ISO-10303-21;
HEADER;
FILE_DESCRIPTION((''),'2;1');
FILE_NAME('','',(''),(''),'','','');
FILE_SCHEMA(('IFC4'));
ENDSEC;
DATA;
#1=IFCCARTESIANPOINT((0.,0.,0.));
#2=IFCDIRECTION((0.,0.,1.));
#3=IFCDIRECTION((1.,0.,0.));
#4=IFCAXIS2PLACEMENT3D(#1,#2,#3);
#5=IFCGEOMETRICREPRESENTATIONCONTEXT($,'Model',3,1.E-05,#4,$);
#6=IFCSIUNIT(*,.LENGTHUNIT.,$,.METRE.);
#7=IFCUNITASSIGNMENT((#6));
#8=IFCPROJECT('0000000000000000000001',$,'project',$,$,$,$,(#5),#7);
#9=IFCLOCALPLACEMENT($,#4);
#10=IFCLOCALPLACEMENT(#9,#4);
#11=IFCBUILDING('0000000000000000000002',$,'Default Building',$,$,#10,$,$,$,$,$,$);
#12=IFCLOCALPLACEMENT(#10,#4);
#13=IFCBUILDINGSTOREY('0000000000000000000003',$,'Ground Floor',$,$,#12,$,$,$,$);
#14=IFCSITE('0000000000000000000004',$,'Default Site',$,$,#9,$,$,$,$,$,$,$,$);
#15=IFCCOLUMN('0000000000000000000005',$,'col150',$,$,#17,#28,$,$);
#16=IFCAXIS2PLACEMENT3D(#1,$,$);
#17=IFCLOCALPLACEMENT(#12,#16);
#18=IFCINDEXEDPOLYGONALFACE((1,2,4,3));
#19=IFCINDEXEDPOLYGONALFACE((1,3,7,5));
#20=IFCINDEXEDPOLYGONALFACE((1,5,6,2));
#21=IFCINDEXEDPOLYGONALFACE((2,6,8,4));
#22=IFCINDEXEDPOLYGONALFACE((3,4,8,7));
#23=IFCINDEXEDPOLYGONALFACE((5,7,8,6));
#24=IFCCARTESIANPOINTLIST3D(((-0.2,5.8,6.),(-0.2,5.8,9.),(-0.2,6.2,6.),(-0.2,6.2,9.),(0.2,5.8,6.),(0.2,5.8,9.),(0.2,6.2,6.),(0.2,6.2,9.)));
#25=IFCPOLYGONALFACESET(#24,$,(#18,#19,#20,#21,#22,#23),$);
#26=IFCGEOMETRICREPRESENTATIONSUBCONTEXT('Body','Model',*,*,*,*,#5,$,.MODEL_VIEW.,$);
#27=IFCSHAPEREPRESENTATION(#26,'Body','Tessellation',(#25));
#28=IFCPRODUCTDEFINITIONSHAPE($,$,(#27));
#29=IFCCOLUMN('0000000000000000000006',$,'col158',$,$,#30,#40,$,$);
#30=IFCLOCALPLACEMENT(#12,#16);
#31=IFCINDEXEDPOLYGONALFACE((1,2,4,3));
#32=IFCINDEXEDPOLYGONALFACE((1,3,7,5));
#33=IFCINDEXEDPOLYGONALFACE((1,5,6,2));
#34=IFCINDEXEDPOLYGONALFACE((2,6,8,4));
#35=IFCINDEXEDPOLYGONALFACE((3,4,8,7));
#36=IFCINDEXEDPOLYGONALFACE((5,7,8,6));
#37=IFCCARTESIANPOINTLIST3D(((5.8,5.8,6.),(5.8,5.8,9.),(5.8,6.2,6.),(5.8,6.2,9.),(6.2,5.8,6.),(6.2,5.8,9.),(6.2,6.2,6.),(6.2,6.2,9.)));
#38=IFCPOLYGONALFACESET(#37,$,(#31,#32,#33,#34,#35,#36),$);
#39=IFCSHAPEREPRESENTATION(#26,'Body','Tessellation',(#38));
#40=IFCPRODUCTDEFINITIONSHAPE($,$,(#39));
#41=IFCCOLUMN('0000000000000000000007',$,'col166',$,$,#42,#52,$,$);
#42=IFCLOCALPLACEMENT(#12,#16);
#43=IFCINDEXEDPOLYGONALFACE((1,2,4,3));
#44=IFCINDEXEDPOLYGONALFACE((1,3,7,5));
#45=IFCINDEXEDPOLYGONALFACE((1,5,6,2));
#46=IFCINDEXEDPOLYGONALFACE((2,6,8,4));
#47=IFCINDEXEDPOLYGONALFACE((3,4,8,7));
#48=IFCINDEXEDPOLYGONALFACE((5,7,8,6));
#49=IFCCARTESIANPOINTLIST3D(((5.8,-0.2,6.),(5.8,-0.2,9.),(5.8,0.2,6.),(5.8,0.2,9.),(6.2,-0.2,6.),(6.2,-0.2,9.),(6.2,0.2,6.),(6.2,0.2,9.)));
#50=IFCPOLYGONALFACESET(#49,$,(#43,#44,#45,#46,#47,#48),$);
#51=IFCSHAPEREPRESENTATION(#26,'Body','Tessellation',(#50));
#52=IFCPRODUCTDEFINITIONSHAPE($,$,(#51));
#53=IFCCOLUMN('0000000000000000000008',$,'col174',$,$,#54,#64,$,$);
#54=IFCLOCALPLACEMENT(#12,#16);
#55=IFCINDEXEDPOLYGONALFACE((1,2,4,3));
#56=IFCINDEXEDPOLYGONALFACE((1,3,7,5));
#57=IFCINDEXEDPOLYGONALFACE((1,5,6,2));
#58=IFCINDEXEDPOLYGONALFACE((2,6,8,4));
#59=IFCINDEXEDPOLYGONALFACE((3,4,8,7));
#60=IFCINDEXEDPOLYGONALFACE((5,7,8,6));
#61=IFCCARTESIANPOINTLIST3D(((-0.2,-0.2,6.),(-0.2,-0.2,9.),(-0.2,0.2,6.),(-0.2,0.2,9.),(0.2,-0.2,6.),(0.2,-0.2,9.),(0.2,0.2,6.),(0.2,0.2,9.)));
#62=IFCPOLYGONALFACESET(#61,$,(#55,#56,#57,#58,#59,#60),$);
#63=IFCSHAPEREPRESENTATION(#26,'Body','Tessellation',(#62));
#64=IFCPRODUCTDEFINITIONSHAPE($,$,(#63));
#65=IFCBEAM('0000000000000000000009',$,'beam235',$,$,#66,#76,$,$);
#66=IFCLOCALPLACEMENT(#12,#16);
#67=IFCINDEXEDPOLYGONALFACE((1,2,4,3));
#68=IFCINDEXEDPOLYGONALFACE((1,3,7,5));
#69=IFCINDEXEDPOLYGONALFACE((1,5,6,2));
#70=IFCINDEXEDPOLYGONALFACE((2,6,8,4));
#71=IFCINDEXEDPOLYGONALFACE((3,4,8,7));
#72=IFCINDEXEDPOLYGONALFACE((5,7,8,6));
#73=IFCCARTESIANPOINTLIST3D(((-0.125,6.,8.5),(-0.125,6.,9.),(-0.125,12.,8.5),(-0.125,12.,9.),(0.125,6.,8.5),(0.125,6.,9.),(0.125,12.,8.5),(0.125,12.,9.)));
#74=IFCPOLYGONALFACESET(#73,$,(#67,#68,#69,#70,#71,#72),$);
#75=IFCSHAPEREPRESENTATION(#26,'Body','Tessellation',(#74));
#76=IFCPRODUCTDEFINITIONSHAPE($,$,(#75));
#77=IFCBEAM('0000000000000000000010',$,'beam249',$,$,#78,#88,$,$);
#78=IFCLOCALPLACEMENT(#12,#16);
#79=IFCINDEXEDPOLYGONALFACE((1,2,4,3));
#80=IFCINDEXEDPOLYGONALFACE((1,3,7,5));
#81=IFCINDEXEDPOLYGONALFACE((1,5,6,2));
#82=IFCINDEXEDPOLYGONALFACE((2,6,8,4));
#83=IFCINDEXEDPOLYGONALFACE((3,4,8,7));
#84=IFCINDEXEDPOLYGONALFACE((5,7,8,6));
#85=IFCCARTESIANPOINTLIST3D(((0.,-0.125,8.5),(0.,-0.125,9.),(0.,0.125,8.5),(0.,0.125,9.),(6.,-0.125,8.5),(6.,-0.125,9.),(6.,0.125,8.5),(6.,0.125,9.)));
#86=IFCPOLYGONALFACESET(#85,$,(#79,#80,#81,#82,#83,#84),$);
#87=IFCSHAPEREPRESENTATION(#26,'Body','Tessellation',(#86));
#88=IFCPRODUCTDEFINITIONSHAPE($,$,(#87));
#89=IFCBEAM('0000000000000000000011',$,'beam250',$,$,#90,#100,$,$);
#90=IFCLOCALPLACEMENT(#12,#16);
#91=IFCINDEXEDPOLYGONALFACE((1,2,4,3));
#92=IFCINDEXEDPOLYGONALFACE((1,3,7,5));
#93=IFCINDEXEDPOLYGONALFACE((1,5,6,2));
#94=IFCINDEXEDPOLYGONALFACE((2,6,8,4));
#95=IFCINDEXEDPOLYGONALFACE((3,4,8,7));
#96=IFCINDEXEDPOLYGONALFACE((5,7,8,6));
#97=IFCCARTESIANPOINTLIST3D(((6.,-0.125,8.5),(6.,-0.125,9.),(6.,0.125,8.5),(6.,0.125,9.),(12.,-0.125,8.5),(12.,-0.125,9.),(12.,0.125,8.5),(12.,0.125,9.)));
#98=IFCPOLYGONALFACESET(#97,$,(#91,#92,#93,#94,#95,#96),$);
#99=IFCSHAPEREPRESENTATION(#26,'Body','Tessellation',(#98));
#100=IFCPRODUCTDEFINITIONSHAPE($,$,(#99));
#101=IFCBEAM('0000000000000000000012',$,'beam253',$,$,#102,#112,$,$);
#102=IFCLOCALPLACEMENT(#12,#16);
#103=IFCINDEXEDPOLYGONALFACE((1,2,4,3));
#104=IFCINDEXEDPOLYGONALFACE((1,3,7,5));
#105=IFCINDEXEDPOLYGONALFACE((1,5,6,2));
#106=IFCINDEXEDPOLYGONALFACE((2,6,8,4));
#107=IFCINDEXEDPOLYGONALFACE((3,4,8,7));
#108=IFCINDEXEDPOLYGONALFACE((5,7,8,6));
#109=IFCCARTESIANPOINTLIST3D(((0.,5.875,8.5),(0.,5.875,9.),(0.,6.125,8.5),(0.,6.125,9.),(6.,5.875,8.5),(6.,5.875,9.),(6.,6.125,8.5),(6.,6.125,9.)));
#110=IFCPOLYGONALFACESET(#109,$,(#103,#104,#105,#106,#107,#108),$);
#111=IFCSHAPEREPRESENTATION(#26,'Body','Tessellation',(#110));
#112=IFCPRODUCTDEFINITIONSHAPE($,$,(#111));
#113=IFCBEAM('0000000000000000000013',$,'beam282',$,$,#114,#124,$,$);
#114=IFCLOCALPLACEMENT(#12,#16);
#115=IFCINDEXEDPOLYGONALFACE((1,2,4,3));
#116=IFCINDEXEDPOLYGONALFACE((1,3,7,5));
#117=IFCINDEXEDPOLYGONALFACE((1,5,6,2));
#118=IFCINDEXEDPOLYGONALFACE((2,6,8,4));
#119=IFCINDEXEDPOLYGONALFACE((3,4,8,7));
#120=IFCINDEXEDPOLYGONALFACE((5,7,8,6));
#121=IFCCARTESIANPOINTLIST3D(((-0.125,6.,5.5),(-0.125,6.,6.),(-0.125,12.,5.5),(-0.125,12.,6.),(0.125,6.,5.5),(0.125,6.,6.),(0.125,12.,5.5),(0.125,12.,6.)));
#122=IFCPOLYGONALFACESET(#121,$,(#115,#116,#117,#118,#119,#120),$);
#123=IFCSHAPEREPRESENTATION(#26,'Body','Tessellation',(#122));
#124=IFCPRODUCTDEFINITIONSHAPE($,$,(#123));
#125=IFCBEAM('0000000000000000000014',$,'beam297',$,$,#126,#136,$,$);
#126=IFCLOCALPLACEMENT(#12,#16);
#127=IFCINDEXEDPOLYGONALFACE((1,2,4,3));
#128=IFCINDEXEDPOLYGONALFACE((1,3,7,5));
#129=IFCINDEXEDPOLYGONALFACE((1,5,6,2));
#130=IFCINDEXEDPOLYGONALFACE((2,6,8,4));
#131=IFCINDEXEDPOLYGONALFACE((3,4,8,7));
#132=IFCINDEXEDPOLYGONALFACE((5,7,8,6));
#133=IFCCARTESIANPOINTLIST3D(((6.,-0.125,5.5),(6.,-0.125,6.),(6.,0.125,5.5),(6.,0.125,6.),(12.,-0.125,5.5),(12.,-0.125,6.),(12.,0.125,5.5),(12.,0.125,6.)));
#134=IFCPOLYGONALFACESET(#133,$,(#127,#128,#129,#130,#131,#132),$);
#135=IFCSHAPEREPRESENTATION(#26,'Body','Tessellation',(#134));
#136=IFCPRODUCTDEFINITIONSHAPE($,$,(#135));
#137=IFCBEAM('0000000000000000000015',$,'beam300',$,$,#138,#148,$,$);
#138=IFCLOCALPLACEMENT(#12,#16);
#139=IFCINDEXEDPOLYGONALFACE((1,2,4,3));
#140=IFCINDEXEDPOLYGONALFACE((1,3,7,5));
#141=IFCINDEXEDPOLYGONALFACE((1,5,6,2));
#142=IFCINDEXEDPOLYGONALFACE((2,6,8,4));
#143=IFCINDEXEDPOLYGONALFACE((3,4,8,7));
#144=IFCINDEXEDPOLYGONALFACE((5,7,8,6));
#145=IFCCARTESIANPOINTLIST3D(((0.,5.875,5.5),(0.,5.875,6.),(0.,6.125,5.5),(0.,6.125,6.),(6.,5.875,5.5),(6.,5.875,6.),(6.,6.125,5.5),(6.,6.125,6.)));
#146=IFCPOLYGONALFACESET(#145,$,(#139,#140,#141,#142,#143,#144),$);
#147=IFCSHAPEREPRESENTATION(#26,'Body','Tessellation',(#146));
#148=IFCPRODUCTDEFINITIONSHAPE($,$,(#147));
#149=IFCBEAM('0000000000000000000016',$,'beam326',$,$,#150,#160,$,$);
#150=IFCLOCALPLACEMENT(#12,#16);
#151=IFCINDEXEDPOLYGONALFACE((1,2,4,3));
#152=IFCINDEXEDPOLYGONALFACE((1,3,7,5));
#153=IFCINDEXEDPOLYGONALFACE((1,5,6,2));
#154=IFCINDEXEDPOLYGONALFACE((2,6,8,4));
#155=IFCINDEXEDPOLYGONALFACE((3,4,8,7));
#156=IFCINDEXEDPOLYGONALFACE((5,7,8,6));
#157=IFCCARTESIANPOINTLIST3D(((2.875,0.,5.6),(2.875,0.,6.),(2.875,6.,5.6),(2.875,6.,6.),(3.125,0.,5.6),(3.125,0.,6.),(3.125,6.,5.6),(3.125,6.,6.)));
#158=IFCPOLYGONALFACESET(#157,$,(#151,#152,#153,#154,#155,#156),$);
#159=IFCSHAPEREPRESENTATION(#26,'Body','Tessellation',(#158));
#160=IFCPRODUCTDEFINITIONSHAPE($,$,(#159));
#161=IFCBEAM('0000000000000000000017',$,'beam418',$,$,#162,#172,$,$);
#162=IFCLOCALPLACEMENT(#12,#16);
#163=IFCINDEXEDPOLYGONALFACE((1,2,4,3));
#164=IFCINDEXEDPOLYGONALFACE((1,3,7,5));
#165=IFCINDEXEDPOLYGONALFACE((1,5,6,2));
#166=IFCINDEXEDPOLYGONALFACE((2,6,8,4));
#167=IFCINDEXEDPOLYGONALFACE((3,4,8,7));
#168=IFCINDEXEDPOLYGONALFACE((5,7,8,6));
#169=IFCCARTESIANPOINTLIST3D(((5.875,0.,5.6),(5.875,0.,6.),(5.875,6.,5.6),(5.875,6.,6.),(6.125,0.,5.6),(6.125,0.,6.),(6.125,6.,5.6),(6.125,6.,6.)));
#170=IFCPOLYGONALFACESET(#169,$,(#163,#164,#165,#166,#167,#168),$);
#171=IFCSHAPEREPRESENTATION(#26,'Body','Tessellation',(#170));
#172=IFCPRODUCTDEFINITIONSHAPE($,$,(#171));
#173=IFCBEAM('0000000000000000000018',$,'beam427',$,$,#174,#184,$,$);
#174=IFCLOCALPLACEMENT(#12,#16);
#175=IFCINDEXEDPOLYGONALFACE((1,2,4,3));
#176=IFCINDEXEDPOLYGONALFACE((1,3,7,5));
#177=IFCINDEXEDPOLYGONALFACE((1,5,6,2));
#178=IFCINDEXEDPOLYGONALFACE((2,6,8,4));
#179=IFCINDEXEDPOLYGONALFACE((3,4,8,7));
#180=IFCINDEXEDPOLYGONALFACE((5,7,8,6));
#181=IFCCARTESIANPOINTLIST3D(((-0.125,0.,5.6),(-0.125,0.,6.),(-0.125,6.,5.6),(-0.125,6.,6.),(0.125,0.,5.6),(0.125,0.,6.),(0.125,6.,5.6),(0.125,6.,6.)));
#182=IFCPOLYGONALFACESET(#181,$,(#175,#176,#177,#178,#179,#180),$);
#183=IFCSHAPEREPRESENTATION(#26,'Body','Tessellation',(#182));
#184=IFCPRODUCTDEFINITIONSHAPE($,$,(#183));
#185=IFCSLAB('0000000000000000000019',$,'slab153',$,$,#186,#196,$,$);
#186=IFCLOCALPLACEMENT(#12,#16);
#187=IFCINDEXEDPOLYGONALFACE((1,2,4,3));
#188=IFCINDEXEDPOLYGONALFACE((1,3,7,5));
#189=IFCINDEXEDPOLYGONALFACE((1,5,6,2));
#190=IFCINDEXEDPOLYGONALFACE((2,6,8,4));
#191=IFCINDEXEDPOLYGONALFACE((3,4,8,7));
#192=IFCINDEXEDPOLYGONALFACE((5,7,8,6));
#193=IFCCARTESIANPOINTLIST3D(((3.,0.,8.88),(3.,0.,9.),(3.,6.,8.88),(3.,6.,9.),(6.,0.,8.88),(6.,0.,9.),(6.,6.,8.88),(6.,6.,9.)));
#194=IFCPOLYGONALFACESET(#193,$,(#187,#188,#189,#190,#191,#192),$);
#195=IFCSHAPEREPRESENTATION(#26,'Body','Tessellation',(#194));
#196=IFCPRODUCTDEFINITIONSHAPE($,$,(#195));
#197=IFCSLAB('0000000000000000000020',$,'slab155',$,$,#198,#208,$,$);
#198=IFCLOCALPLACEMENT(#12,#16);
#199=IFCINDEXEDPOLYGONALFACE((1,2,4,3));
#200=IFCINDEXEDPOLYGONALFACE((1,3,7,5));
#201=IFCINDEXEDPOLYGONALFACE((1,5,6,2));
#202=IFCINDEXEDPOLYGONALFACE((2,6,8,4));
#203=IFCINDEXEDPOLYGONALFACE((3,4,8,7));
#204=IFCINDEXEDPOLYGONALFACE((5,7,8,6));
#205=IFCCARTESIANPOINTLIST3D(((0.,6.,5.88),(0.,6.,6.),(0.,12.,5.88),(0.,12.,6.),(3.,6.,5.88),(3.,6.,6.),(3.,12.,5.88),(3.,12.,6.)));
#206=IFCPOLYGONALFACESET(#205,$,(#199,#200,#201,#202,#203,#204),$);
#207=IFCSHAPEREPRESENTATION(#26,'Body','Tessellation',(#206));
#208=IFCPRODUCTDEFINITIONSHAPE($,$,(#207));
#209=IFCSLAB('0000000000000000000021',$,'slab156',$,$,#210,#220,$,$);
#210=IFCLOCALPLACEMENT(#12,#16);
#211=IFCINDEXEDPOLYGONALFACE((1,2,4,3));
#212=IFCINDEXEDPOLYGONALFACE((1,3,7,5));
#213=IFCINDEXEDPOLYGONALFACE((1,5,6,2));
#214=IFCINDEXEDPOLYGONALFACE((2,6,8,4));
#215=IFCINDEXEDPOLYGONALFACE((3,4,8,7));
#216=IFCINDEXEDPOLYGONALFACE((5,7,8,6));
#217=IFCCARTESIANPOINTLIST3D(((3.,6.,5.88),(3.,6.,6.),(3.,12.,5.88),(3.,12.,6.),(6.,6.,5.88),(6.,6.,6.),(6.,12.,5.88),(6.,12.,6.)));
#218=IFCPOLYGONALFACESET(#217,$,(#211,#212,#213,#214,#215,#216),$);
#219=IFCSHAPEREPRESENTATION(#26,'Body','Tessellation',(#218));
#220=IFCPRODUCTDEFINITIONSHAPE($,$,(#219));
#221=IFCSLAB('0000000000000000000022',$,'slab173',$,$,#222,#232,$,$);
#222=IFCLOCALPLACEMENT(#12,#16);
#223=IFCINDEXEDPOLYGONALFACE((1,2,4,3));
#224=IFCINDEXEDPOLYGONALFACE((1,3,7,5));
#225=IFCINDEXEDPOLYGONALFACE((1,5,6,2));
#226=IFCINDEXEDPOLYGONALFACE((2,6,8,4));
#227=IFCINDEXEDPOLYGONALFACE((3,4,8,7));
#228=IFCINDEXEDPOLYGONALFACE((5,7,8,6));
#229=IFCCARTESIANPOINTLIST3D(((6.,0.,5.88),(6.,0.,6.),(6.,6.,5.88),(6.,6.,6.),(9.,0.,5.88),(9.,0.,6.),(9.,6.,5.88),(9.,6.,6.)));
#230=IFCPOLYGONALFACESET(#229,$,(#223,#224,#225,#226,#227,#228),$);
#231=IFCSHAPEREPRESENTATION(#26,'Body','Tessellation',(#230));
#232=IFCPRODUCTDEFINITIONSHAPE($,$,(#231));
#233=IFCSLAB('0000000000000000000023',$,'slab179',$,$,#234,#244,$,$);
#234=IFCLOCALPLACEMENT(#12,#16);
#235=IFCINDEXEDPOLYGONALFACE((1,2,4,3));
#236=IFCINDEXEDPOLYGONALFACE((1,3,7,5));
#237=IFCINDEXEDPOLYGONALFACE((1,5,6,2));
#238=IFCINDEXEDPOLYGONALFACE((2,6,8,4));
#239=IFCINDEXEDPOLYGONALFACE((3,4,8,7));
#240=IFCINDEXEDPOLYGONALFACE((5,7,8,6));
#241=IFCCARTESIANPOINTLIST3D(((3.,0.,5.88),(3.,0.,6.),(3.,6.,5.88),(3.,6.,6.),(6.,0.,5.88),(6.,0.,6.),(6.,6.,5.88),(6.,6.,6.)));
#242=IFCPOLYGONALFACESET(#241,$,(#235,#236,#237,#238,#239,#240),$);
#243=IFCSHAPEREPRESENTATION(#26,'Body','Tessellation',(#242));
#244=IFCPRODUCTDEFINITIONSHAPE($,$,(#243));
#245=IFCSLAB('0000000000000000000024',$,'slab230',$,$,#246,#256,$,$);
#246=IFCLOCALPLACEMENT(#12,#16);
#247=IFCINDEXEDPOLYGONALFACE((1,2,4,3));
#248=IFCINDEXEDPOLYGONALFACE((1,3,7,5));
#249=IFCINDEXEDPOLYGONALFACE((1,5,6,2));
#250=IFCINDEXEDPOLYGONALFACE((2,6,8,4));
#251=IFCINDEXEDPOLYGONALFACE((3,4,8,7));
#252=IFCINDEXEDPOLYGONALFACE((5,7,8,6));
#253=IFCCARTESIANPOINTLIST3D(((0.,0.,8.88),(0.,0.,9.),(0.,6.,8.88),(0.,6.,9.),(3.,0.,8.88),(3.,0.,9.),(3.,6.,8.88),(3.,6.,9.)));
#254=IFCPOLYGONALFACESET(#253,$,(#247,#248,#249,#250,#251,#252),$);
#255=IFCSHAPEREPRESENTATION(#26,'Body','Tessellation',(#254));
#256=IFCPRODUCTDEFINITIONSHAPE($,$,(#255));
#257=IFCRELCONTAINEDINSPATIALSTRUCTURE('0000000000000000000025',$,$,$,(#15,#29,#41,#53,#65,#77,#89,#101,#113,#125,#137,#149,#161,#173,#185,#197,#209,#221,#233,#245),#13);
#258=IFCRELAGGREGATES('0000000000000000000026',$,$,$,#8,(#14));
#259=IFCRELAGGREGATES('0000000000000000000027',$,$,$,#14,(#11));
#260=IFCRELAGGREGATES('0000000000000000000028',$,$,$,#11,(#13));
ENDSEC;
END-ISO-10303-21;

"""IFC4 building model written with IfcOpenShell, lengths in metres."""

from ifc_helpers import new_model, si_unit, frame, origin_with_axes, place, context, subcontext, project, spatial, indexed_curve, outline, extrude, element, save


model = new_model("IFC4")

# Units and contexts
model_context = context("Model", 3, precision=1e-05, world=origin_with_axes())
body_context = subcontext(model_context, "Body", "Model", "MODEL_VIEW")
ifc_project = project(units=[si_unit("LENGTHUNIT", "METRE")], contexts=[model_context])

# Site, building, storey
site_placement = place(None, origin_with_axes())
site = spatial("IfcSite", under=ifc_project, at=site_placement, Name="Default Site")
building_placement = place(site_placement, origin_with_axes())
building = spatial("IfcBuilding", under=site, at=building_placement, Name="Default Building")
storey_placement = place(building_placement, origin_with_axes())
storey = spatial("IfcBuildingStorey", under=building, at=storey_placement, Name="Ground Floor")

# Columns
for number, where, z_axis, x_axis, name in (
    (1, (-0.2, 5.8, 6.0), (0.0, 0.0, 1.0), (1.0, 0.0, 0.0), "col150"),
    (2, (5.8, 5.8, 6.0), (0.0, 0.0, 1.0), (1.0, 0.0, 0.0), "col158"),
    (3, (5.8, -0.2, 6.0), (0.0, 0.0, 1.0), (1.0, 0.0, 0.0), "col166"),
    (4, (-0.2, -0.2, 6.0), (0.0, 0.0, 1.0), (1.0, 0.0, 0.0), "col174"),
):
    element("IfcColumn", number, at=place(storey_placement, frame(where, z_axis=z_axis, x_axis=x_axis)), inside=storey, Name=name, context=body_context, shape_type="SweptSolid", body=[
        extrude(outline(indexed_curve([(0.0, 0.0), (0.0, 0.4), (0.4, 0.4), (0.4, 0.0), (0.0, 0.0)], self_intersect=False)), origin_with_axes(), (0.0, 0.0, 1.0), 3.0),
    ])

# Beams
for number, where, z_axis, x_axis, name in (
    (5, (0.125, 6.0, 8.5), (0.0, 0.0, 1.0), (0.0, 1.0, 0.0), "beam235"),
    (6, (0.0, -0.125, 8.5), (0.0, 0.0, 1.0), (1.0, 0.0, 0.0), "beam249"),
    (7, (6.0, -0.125, 8.5), (0.0, 0.0, 1.0), (1.0, 0.0, 0.0), "beam250"),
    (8, (0.0, 5.875, 8.5), (0.0, 0.0, 1.0), (1.0, 0.0, 0.0), "beam253"),
    (9, (0.125, 6.0, 5.5), (0.0, 0.0, 1.0), (0.0, 1.0, 0.0), "beam282"),
    (10, (6.0, -0.125, 5.5), (0.0, 0.0, 1.0), (1.0, 0.0, 0.0), "beam297"),
    (11, (0.0, 5.875, 5.5), (0.0, 0.0, 1.0), (1.0, 0.0, 0.0), "beam300"),
):
    element("IfcBeam", number, at=place(storey_placement, frame(where, z_axis=z_axis, x_axis=x_axis)), inside=storey, Name=name, context=body_context, shape_type="SweptSolid", body=[
        extrude(outline(indexed_curve([(0.0, 0.0), (0.0, 0.25), (6.0, 0.25), (6.0, 0.0), (0.0, 0.0)], self_intersect=False)), origin_with_axes(), (0.0, 0.0, 1.0), 0.5),
    ])
for number, where, z_axis, x_axis, name in (
    (12, (2.875, 6.0, 5.6), (0.0, 0.0, 1.0), (0.0, -1.0, 0.0), "beam326"),
    (13, (5.875, 6.0, 5.6), (0.0, 0.0, 1.0), (0.0, -1.0, 0.0), "beam418"),
    (14, (-0.125, 6.0, 5.6), (0.0, 0.0, 1.0), (0.0, -1.0, 0.0), "beam427"),
):
    element("IfcBeam", number, at=place(storey_placement, frame(where, z_axis=z_axis, x_axis=x_axis)), inside=storey, Name=name, context=body_context, shape_type="SweptSolid", body=[
        extrude(outline(indexed_curve([(0.0, 0.0), (0.0, 0.25), (6.0, 0.25), (6.0, 0.0), (0.0, 0.0)], self_intersect=False)), origin_with_axes(), (0.0, 0.0, 1.0), 0.4),
    ])

# Slabs
for number, where, z_axis, x_axis, name in (
    (15, (3.0, 0.0, 8.88), (0.0, 0.0, 1.0), (1.0, 0.0, 0.0), "slab153"),
    (16, (0.0, 6.0, 5.88), (0.0, 0.0, 1.0), (1.0, 0.0, 0.0), "slab155"),
    (17, (3.0, 6.0, 5.88), (0.0, 0.0, 1.0), (1.0, 0.0, 0.0), "slab156"),
    (18, (6.0, 0.0, 5.88), (0.0, 0.0, 1.0), (1.0, 0.0, 0.0), "slab173"),
    (19, (3.0, 0.0, 5.88), (0.0, 0.0, 1.0), (1.0, 0.0, 0.0), "slab179"),
    (20, (0.0, 0.0, 8.88), (0.0, 0.0, 1.0), (1.0, 0.0, 0.0), "slab230"),
):
    element("IfcSlab", number, at=place(storey_placement, frame(where, z_axis=z_axis, x_axis=x_axis)), inside=storey, Name=name, context=body_context, shape_type="SweptSolid", body=[
        extrude(outline(indexed_curve([(0.0, 0.0), (0.0, 6.0), (3.0, 6.0), (3.0, 0.0), (0.0, 0.0)], self_intersect=False)), origin_with_axes(), (0.0, 0.0, 1.0), 0.12),
    ])

save(model, "model.ifc")
